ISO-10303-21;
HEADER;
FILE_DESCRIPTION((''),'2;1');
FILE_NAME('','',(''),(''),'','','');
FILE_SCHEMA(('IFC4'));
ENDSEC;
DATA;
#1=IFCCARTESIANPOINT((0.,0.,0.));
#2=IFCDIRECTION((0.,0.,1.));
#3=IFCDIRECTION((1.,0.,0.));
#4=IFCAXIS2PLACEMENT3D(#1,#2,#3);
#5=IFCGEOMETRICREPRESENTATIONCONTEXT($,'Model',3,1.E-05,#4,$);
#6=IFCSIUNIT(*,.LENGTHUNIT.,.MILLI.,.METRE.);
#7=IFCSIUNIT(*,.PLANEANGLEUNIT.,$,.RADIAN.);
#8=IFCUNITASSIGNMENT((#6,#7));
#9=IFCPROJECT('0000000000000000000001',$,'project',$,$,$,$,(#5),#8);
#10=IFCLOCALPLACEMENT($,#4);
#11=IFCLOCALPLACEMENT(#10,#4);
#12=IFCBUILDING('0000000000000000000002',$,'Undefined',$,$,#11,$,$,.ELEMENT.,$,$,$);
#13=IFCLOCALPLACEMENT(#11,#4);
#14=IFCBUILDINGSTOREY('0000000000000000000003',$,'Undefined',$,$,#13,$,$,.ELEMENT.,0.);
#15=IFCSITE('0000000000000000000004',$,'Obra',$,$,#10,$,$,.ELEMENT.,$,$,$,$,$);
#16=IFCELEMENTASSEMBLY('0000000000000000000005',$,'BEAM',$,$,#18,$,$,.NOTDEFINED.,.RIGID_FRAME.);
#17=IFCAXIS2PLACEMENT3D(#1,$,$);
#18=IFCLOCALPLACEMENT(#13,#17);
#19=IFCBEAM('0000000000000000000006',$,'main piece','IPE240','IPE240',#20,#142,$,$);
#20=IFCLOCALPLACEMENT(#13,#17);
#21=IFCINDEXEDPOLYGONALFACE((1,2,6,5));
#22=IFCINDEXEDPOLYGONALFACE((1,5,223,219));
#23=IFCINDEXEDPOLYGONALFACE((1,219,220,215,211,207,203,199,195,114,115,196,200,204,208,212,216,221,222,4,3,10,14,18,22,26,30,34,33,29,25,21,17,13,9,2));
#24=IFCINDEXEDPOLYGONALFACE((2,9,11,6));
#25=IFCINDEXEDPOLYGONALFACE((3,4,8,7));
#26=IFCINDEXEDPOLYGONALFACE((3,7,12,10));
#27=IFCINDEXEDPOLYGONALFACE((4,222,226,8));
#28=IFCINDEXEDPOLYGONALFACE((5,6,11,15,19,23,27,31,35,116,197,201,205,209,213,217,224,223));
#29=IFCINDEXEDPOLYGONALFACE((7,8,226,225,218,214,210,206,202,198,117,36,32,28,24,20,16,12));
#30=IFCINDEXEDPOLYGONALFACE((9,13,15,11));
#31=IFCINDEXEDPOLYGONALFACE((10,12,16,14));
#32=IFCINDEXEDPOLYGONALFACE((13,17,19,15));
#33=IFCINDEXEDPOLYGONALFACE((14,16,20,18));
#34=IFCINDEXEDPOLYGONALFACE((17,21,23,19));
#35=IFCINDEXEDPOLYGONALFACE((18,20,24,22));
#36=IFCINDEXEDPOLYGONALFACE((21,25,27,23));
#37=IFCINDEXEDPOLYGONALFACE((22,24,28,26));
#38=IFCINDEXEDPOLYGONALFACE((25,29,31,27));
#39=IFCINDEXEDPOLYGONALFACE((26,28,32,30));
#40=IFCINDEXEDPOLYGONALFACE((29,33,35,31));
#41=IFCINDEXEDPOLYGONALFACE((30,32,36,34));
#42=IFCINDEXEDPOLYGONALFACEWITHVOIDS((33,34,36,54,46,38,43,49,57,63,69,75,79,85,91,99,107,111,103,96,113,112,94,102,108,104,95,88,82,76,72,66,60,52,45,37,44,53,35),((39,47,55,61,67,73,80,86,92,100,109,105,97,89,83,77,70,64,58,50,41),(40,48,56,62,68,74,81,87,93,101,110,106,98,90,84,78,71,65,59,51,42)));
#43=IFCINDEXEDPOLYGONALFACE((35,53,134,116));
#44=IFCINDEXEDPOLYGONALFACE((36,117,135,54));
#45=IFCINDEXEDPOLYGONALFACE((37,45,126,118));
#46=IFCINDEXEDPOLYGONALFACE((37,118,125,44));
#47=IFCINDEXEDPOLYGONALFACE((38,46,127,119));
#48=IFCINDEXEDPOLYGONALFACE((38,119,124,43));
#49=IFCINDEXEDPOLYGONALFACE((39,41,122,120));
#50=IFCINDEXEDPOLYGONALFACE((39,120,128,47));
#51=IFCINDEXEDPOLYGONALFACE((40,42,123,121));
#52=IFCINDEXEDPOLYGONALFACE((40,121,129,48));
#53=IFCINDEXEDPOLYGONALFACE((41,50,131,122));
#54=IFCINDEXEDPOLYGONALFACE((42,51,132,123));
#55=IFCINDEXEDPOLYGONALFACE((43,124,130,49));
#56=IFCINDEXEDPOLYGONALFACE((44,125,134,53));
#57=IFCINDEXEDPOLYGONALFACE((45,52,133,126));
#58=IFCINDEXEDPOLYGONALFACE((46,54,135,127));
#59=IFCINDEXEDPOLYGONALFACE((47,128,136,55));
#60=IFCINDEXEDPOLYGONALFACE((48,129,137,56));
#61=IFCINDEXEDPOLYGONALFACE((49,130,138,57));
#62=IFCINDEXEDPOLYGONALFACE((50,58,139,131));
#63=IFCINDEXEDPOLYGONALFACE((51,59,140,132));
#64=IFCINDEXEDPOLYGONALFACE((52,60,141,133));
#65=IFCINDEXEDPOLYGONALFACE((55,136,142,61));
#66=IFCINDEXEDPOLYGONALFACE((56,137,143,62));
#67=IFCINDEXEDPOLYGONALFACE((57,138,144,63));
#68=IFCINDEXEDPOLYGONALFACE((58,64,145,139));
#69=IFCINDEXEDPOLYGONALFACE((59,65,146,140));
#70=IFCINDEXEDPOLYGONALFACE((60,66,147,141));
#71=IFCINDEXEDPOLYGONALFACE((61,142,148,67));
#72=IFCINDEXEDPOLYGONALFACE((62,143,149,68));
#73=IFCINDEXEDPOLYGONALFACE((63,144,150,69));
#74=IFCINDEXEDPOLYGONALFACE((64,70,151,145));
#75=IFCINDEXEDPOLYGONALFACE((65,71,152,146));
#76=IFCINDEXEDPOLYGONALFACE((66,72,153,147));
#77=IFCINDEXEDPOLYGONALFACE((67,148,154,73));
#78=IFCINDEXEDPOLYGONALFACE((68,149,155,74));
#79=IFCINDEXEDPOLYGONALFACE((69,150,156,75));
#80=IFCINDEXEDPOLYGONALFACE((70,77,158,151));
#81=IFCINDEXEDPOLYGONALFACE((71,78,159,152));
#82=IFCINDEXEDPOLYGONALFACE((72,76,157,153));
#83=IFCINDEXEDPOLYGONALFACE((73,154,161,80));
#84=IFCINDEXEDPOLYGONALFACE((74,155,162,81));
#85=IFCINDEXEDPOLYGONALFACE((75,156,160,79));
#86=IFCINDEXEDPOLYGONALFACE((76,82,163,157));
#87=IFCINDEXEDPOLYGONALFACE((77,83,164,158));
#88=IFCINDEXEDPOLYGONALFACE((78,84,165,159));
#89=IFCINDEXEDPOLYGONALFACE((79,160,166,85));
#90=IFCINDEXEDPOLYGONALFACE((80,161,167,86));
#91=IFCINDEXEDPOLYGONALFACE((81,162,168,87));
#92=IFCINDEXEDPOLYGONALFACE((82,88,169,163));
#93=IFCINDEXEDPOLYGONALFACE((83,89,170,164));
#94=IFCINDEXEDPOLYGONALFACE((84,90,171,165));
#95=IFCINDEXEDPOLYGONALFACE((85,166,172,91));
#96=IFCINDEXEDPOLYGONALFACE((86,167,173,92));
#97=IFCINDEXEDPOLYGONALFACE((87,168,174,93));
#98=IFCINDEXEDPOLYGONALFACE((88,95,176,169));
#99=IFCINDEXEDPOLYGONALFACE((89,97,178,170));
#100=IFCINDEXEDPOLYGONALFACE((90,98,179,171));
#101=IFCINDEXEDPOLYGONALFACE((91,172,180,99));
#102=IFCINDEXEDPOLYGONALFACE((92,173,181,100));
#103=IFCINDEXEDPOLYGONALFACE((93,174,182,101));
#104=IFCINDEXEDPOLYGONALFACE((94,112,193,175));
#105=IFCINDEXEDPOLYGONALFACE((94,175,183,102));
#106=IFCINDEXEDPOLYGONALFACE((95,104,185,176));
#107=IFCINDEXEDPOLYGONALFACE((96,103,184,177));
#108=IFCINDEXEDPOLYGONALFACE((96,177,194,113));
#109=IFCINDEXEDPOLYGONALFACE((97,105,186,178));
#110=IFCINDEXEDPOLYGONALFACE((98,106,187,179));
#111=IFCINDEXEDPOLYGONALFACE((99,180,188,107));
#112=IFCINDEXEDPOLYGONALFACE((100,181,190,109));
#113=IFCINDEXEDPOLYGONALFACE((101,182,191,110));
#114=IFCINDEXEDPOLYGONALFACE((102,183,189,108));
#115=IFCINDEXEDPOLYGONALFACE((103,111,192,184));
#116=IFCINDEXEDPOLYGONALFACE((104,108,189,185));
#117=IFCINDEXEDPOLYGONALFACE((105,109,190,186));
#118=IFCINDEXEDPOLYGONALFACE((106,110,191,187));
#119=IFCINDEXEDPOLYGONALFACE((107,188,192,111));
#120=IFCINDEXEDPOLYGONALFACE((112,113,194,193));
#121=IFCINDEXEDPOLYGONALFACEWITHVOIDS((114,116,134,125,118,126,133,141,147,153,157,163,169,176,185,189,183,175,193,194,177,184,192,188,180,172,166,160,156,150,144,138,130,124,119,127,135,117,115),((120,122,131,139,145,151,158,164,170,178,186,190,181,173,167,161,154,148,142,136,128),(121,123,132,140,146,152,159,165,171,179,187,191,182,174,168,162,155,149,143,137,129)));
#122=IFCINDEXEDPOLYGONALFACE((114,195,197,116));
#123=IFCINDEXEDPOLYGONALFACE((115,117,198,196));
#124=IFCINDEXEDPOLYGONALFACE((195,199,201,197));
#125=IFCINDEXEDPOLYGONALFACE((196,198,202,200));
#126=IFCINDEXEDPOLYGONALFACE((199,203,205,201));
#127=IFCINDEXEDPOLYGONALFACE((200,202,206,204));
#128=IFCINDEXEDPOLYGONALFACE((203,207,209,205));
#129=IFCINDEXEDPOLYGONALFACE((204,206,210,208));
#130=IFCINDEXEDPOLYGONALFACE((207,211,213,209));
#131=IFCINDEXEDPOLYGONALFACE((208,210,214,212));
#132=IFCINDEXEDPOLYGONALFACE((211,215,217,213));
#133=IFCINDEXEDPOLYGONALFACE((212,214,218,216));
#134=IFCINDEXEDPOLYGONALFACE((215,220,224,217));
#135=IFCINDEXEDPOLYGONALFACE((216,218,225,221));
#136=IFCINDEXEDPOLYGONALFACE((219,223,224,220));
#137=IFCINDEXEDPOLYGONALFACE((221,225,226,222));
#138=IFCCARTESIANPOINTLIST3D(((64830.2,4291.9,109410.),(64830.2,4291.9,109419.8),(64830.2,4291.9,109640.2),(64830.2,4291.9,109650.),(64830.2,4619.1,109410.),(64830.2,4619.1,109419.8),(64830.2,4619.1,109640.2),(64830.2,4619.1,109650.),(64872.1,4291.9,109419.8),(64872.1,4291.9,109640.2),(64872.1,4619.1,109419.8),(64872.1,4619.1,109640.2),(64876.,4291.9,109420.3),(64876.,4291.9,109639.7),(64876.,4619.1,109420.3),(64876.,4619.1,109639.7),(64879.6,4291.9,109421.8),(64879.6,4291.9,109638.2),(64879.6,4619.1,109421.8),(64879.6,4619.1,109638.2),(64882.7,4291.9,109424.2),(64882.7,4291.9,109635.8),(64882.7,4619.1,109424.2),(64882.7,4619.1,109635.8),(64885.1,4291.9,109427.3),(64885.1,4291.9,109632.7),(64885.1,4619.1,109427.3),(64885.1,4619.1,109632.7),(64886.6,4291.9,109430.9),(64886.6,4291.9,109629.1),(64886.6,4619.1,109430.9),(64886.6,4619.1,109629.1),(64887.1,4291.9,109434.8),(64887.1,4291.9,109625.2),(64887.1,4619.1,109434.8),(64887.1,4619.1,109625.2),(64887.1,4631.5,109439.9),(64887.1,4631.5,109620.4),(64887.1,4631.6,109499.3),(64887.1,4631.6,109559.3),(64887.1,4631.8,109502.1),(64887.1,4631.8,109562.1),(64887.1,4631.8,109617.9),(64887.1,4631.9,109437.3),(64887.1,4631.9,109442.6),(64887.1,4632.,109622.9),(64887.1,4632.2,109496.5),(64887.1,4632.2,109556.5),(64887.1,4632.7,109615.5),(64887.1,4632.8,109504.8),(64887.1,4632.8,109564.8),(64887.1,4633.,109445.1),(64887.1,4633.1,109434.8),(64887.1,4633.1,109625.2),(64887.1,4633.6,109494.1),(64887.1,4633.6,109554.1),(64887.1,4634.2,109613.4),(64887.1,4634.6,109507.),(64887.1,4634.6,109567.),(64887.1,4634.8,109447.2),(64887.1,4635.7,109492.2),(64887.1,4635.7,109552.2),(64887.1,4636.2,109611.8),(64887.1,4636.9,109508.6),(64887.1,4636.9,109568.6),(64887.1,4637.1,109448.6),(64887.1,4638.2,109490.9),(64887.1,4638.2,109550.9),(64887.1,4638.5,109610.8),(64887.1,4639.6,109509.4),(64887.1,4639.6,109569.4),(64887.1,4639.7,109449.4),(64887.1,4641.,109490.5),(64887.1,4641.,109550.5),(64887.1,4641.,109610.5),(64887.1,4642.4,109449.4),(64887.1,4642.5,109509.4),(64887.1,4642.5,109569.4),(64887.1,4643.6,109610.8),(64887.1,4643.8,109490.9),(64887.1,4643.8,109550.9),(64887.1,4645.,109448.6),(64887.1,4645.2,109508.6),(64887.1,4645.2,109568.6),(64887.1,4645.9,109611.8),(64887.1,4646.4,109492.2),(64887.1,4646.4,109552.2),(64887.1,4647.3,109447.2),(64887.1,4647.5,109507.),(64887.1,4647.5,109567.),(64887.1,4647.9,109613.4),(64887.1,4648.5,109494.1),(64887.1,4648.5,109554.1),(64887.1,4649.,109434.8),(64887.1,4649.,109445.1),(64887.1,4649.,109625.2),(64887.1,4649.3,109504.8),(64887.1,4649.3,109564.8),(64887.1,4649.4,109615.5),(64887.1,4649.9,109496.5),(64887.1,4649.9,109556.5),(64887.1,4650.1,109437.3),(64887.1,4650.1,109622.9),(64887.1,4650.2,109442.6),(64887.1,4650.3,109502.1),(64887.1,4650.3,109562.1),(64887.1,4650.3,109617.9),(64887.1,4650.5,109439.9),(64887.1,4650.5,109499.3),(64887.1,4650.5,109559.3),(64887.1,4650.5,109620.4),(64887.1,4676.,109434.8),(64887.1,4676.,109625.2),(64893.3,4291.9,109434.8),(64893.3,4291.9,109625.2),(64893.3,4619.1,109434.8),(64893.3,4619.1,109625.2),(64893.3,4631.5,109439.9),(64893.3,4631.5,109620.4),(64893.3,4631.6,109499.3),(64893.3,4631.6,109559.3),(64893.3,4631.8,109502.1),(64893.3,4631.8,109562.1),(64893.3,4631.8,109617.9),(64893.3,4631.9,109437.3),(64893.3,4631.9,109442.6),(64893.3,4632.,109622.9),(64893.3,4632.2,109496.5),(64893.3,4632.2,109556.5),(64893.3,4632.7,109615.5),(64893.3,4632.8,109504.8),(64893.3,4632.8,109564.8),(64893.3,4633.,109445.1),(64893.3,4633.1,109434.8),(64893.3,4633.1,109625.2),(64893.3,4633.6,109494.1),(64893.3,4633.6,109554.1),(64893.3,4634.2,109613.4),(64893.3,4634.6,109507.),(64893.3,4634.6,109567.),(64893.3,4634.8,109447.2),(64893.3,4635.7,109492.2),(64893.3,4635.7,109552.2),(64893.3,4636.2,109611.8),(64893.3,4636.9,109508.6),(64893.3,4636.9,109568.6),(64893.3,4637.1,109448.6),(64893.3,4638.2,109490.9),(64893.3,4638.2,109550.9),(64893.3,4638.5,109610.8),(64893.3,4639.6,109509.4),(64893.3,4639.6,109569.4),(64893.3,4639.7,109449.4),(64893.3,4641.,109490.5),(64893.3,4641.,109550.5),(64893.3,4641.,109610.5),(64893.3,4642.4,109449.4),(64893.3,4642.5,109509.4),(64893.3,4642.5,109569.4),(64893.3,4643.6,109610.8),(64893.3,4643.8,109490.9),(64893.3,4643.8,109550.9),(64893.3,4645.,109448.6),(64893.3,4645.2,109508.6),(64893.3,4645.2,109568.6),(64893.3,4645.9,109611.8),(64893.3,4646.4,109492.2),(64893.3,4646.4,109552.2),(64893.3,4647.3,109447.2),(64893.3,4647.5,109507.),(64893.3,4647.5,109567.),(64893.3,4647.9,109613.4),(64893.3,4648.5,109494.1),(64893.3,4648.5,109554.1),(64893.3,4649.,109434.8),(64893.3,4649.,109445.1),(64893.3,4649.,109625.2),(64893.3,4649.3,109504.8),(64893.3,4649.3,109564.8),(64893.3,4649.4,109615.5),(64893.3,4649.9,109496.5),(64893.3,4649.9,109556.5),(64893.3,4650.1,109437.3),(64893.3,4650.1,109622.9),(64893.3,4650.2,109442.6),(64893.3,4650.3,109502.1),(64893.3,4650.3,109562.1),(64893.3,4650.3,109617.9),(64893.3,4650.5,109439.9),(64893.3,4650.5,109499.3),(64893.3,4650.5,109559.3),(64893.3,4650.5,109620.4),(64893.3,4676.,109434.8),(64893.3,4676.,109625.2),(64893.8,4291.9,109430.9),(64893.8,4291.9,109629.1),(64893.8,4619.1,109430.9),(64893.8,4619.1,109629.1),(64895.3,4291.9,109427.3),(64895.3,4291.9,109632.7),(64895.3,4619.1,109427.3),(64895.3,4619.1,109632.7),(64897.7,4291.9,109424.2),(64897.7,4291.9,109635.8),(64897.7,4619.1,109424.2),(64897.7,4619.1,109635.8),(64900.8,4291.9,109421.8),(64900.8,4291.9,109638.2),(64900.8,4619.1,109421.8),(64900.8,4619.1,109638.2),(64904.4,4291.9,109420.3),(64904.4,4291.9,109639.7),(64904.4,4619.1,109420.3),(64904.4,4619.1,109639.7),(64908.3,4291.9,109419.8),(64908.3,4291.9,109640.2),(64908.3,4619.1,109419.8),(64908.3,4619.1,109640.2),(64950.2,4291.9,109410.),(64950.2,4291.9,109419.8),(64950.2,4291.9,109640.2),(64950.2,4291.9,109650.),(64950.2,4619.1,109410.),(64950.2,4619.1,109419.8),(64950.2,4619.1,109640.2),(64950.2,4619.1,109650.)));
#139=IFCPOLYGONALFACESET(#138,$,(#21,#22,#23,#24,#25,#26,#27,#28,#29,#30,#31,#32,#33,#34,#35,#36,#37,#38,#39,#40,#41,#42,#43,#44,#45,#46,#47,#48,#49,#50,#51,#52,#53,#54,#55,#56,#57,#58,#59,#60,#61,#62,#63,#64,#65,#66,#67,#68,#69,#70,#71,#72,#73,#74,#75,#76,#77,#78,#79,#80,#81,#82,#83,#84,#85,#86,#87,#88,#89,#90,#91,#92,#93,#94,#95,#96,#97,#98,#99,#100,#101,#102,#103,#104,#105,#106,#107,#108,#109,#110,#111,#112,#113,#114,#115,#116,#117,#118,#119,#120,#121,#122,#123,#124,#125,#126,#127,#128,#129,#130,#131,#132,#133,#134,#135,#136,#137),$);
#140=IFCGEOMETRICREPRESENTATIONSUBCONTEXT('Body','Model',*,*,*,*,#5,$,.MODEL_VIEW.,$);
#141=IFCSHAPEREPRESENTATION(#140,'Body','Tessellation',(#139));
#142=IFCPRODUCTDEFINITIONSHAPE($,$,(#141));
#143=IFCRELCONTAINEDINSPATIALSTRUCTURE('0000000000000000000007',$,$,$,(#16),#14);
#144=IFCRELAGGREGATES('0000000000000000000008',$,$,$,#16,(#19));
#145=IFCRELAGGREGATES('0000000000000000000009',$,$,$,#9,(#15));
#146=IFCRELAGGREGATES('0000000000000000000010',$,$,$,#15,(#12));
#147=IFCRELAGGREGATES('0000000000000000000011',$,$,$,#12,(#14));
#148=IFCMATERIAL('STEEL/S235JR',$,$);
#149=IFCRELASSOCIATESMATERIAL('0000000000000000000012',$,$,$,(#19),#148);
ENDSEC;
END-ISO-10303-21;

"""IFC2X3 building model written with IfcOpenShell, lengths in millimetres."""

from ifc_helpers import new_model, si_unit, frame, origin_with_axes, origin_2d_with_axis, place, context, subcontext, project, spatial, rectangle, circle, i_section, extrude, clip, halfspace, source, transform, mapped, material, element, aggregate, save


model = new_model("IFC2X3")

# Units and contexts
model_context = context("Model", 3, precision=1e-05, world=origin_with_axes())
body_context = subcontext(model_context, "Body", "Model", "MODEL_VIEW")
ifc_project = project(units=[si_unit("LENGTHUNIT", "METRE", prefix="MILLI"), si_unit("PLANEANGLEUNIT", "RADIAN")], contexts=[model_context])

# Site, building, storey
site_placement = place(None, origin_with_axes())
site = spatial("IfcSite", under=ifc_project, at=site_placement, Name="Obra", CompositionType="ELEMENT")
building_placement = place(site_placement, origin_with_axes())
building = spatial("IfcBuilding", under=site, at=building_placement, Name="Undefined", CompositionType="ELEMENT")
storey_placement = place(building_placement, origin_with_axes())
storey = spatial("IfcBuildingStorey", under=building, at=storey_placement, Name="Undefined", CompositionType="ELEMENT", Elevation=0.0)

# Element assembly, beam, openings
ifc_material_1 = material(Name="STEEL/S235JR")
assembly_1_placement = place(storey_placement, origin_with_axes())
assembly_1 = element("IfcElementAssembly", 1, at=assembly_1_placement, inside=storey, Name="BEAM", AssemblyPlace="NOTDEFINED", PredefinedType="RIGID_FRAME")
beam_1_placement = place(assembly_1_placement, frame((64890.2, 4291.9, 109530.0), z_axis=(0.0, 0.0, 1.0), x_axis=(0.0, 1.0, 0.0)))
beam_1 = element("IfcBeam", 2, at=beam_1_placement, material=ifc_material_1, Name="main piece", Description="IPE240", ObjectType="IPE240", context=body_context, shape_type="Clipping", body=[
    clip(extrude(i_section(OverallWidth=120.0, OverallDepth=240.0, WebThickness=6.2, FlangeThickness=9.8, FilletRadius=15.0, at=origin_2d_with_axis()), frame((384.1, 0.0, 0.0), z_axis=(-1.0, 0.0, 0.0), x_axis=(0.0, -1.0, 0.0)), (0.0, 0.0, 1.0), 384.1), halfspace(frame((384.1, 0.0, -220.0), z_axis=(-1.0, 0.0, 0.0), x_axis=(0.0, 1.0, 0.0)), True)),
])
opening_1_placement = place(assembly_1_placement, frame((64890.2, 4291.9, 109530.0), z_axis=(0.0, 0.0, 1.0), x_axis=(0.0, 1.0, 0.0)))
element("IfcOpeningElement", 3, at=opening_1_placement, cuts=beam_1, ObjectType="Recess", context=body_context, shape_type="SweptSolid", body=[
    extrude(rectangle(XDim=25.8, YDim=68.9, at=origin_2d_with_axis()), frame((361.7, 61.0, -108.1), z_axis=(0.0, -1.0, 0.0), x_axis=(0.0, 0.0, -1.0)), (0.0, 0.0, 1.0), 122.0),
])
opening_2_placement = place(assembly_1_placement, frame((64890.2, 4291.9, 109530.0), z_axis=(0.0, 0.0, 1.0), x_axis=(0.0, 1.0, 0.0)))
element("IfcOpeningElement", 4, at=opening_2_placement, cuts=beam_1, ObjectType="Recess", context=body_context, shape_type="SweptSolid", body=[
    extrude(rectangle(XDim=25.8, YDim=68.9, at=origin_2d_with_axis()), frame((361.7, 61.0, 108.1), z_axis=(0.0, -1.0, 0.0), x_axis=(0.0, 0.0, -1.0)), (0.0, 0.0, 1.0), 122.0),
])
shared_shape_1 = source(origin_with_axes(), body_context, "Body", "SweptSolid", [
    extrude(circle(Radius=9.5, at=origin_2d_with_axis()), frame((0.0, -3.2, 0.0), z_axis=(0.0, 1.0, 0.0), x_axis=(1.0, 0.0, 0.0)), (0.0, 0.0, 1.0), 6.4),
])
opening_3_placement = place(assembly_1_placement, frame((64890.2, 4676.0, 109650.0), z_axis=(0.0, -1.0, 0.0), x_axis=(0.0, 0.0, -1.0)))
element("IfcOpeningElement", 5, at=opening_3_placement, cuts=beam_1, ObjectType="Opening", context=body_context, shape_type="MappedRepresentation", body=[
    mapped(shared_shape_1, transform((30.0, 0.0, 35.0))),
    mapped(shared_shape_1, transform((90.0, 0.0, 35.0))),
    mapped(shared_shape_1, transform((150.0, 0.0, 35.0))),
    mapped(shared_shape_1, transform((210.0, 0.0, 35.0))),
])

aggregate(assembly_1, [beam_1])

save(model, "model.ifc")
